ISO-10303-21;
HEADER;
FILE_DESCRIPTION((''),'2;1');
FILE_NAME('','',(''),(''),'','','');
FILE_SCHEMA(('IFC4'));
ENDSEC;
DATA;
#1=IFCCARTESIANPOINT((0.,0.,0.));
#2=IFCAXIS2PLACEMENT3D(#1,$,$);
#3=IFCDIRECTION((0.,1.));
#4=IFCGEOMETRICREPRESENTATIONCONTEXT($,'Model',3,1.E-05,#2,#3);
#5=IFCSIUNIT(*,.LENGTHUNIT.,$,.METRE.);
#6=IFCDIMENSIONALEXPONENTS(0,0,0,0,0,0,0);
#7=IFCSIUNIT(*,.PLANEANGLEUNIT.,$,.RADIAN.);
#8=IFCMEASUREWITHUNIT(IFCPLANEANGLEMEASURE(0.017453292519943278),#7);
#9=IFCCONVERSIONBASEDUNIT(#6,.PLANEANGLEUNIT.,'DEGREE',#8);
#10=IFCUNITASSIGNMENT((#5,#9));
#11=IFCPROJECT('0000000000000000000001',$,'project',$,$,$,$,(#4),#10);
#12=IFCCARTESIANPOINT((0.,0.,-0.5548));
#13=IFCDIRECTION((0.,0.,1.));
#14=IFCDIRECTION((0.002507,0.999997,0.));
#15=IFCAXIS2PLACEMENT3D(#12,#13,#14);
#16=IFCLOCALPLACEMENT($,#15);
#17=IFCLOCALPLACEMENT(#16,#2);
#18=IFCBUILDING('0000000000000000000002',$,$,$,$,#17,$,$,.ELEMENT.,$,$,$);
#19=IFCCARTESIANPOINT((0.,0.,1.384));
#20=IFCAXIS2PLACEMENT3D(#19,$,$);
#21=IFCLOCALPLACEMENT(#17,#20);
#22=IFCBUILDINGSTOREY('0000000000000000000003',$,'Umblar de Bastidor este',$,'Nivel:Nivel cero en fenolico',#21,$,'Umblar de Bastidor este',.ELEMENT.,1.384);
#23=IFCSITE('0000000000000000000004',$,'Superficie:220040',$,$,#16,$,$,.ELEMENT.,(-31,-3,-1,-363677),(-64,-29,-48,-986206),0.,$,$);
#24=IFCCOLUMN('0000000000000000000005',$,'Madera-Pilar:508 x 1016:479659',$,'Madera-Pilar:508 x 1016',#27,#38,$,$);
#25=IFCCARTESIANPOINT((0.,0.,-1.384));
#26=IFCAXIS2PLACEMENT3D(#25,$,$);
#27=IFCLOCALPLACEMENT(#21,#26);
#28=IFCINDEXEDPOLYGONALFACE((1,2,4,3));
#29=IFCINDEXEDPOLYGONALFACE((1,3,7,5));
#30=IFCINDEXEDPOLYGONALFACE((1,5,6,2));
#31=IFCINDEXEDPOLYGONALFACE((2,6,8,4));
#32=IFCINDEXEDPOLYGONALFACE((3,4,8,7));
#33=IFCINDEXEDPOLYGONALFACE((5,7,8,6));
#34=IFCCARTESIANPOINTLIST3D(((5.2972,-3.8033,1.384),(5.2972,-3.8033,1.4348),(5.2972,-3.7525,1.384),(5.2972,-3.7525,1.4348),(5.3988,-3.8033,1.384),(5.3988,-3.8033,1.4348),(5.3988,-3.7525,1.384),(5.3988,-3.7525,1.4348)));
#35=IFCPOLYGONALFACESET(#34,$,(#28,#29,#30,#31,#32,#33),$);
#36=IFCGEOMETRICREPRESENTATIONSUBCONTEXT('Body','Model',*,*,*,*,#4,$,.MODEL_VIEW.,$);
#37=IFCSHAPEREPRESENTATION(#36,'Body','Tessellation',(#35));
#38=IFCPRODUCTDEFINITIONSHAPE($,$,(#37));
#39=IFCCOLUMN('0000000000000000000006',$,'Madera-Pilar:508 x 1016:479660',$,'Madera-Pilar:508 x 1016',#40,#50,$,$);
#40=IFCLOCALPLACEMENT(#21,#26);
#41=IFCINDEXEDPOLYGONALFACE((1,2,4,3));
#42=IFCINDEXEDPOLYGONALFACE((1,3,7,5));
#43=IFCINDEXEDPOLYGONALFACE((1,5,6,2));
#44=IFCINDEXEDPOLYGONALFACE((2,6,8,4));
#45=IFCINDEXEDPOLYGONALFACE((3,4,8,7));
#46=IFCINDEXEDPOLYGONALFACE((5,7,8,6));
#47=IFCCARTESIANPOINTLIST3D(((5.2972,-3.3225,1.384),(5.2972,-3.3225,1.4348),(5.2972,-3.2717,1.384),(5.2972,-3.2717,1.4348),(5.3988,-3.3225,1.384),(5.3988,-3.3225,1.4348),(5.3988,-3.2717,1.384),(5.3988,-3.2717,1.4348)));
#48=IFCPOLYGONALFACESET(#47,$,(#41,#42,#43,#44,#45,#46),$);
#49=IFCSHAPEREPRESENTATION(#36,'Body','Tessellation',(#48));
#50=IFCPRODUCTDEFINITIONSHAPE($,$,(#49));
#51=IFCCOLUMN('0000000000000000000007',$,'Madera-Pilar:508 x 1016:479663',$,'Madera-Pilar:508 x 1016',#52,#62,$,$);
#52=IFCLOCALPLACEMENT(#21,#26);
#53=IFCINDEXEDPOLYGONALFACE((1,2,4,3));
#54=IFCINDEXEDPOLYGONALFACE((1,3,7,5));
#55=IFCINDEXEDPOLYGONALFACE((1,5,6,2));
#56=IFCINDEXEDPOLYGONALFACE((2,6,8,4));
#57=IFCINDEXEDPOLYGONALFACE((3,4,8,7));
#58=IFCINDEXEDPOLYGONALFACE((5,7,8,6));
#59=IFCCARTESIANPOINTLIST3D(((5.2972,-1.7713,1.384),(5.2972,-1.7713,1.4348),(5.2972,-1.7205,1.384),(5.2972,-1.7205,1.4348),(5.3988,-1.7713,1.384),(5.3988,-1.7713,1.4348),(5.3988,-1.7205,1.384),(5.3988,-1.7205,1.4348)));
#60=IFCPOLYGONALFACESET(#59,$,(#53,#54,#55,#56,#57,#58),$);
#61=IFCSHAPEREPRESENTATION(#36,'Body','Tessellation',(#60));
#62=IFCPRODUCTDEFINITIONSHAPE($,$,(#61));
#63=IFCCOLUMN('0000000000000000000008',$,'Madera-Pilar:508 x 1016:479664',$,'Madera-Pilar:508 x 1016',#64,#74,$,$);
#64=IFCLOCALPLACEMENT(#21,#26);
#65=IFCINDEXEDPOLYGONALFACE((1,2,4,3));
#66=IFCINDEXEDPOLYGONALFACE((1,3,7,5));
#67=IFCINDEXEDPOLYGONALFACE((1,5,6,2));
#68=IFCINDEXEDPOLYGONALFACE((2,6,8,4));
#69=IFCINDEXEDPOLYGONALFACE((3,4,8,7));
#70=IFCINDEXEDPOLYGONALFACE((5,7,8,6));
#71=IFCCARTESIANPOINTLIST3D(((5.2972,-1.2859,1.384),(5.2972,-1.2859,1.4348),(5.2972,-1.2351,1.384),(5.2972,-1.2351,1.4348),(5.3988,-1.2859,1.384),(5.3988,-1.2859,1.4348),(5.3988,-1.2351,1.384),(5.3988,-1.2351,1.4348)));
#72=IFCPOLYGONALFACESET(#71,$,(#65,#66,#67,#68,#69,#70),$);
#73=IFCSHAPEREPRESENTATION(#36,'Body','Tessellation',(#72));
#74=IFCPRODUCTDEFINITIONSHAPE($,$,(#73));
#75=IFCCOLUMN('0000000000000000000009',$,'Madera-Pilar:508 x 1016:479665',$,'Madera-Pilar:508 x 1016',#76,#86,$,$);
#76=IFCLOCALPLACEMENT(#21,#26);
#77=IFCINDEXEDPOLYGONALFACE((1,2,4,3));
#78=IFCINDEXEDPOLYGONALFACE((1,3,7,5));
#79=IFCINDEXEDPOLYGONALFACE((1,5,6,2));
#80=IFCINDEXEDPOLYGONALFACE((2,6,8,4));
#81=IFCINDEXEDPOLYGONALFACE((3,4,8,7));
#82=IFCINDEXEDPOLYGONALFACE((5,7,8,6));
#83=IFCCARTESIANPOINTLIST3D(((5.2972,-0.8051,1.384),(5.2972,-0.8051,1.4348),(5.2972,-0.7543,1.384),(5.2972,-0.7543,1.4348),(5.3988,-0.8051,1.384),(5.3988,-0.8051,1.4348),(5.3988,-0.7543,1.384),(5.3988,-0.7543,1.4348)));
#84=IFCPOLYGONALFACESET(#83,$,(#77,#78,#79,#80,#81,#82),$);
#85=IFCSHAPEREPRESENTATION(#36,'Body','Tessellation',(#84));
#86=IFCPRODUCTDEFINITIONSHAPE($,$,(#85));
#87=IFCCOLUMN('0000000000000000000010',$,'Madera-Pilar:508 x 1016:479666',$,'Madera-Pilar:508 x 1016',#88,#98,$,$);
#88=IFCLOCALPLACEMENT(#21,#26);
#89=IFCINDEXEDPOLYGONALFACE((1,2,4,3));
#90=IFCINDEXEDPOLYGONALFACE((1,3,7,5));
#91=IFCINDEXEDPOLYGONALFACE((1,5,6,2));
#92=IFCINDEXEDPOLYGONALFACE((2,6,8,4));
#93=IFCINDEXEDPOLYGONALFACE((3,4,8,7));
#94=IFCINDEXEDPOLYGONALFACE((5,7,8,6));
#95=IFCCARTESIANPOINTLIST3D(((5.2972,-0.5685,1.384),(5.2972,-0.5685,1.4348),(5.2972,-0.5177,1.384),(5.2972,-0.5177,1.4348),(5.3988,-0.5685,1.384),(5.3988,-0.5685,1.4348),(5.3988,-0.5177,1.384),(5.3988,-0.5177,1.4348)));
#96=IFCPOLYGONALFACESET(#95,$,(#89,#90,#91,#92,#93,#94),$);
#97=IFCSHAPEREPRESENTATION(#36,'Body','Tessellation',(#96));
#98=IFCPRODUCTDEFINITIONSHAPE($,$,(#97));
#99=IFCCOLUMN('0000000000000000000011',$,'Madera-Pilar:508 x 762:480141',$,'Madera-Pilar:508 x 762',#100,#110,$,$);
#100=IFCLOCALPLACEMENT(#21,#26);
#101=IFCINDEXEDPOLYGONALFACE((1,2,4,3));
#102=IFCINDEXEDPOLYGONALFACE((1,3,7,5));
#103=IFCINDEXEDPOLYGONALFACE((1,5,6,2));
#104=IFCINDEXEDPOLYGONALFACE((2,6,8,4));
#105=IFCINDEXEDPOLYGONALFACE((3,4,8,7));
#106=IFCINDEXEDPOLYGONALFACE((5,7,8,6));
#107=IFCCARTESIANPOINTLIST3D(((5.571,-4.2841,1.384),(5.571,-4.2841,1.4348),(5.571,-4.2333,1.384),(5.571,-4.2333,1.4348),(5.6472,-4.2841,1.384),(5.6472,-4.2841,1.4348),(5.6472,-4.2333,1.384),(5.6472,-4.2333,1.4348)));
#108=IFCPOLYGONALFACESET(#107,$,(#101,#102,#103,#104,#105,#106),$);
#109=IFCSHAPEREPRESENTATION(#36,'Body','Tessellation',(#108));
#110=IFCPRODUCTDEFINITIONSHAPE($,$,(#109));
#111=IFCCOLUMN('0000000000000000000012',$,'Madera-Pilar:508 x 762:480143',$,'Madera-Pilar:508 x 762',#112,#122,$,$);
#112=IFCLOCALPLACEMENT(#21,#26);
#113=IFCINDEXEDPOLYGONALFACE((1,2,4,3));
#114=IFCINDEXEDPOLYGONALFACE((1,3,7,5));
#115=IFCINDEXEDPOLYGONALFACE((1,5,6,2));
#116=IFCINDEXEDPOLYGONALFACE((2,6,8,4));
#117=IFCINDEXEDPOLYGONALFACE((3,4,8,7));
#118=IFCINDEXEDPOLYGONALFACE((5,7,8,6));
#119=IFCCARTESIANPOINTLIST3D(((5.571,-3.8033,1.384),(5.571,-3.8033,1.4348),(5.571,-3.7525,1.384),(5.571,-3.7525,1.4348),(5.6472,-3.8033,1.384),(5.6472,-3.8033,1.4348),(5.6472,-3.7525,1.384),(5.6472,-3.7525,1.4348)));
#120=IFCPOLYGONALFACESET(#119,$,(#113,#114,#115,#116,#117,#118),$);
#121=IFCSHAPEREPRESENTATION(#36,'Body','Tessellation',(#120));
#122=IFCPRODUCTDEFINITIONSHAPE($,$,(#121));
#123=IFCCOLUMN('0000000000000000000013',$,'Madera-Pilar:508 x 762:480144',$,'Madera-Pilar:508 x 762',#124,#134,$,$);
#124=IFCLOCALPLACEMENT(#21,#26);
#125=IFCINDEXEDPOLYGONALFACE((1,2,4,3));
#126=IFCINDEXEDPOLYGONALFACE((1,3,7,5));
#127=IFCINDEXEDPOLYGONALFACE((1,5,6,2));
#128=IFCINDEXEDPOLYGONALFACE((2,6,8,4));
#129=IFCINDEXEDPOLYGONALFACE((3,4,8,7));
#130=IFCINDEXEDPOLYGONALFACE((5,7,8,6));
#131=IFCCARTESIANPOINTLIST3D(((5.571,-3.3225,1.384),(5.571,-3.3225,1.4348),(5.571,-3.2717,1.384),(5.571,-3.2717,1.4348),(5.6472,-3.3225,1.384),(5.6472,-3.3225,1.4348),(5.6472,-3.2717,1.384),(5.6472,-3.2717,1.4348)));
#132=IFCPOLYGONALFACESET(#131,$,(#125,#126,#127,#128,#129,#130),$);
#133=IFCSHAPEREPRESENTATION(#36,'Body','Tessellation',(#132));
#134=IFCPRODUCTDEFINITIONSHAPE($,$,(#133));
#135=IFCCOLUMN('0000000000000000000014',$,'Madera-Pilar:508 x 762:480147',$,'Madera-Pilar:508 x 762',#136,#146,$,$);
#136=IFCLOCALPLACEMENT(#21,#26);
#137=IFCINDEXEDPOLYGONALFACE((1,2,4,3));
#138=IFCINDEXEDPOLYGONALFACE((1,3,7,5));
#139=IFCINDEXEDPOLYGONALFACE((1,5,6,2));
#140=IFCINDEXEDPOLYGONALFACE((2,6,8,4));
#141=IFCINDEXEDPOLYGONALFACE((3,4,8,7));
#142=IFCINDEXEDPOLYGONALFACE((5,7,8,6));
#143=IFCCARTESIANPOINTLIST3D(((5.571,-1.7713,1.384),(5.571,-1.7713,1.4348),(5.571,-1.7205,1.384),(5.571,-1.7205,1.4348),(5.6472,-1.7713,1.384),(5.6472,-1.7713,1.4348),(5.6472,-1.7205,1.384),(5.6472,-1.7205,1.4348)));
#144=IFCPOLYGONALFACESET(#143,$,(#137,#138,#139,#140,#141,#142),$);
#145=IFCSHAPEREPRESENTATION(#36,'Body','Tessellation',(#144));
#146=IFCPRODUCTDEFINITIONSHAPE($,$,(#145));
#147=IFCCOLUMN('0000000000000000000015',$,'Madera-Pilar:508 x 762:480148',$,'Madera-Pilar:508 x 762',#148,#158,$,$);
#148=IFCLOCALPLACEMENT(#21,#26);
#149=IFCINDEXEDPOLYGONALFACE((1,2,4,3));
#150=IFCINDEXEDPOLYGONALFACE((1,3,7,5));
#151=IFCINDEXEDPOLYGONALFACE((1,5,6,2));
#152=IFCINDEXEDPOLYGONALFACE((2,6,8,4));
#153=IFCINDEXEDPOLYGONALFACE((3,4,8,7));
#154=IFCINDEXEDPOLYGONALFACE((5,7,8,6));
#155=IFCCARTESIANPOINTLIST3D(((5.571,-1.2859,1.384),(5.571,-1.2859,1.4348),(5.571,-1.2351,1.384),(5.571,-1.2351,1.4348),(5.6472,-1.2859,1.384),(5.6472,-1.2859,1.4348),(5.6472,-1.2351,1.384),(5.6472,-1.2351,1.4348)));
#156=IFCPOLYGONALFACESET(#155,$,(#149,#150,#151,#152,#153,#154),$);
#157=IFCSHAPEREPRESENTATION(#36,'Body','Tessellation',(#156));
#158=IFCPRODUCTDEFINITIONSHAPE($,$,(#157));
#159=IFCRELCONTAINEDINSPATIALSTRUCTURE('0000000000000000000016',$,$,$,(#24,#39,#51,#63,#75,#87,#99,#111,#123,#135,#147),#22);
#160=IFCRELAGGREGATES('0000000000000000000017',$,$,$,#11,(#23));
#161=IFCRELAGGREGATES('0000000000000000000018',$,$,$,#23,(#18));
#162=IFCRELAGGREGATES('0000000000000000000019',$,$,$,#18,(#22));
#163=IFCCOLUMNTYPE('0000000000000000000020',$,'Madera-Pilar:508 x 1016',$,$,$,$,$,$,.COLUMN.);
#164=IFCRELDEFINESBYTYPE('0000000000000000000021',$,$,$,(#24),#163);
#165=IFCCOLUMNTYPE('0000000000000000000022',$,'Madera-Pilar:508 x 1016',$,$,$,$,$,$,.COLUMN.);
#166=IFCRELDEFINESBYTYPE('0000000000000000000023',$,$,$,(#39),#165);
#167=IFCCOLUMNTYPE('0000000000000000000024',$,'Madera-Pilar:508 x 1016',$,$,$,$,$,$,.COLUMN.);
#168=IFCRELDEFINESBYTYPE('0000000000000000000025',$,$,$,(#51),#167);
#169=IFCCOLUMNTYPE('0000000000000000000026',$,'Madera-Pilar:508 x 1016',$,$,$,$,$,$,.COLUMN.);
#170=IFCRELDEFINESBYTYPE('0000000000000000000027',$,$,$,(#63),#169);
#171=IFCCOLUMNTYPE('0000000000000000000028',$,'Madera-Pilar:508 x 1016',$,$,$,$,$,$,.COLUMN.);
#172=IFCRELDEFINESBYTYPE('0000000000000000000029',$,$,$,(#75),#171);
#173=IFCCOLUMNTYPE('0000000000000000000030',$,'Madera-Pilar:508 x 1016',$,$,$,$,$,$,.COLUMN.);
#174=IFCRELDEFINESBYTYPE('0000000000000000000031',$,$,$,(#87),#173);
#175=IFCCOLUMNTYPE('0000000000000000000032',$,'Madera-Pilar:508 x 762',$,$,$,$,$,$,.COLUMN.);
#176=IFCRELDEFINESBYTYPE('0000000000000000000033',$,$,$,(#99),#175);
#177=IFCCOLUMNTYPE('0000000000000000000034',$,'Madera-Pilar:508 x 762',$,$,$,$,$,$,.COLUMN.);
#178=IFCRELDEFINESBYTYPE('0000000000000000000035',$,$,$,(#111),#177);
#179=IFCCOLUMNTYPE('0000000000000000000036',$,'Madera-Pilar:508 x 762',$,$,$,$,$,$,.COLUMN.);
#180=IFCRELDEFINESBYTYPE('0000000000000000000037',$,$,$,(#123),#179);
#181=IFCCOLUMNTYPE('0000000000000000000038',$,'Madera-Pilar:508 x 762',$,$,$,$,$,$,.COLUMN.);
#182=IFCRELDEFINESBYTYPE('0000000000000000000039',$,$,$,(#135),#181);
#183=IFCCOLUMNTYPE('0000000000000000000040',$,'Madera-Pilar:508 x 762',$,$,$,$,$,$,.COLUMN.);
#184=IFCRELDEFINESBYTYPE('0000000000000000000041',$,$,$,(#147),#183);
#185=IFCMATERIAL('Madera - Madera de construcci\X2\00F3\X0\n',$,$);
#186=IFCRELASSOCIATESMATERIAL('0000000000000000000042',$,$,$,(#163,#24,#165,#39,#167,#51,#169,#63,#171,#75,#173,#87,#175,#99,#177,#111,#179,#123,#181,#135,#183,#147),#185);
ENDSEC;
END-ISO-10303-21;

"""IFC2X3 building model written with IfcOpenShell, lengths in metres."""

from ifc_helpers import new_model, entity, si_unit, converted_unit, direction, frame, frame_2d, origin, origin_2d_with_axis, place, context, subcontext, project, spatial, rectangle, extrude, source, transform, mapped, material, type_object, type_shapes, element, save


model = new_model("IFC2X3")

# Units and contexts
model_context = context("Model", 3, precision=1e-05, world=origin(), true_north=direction((0.0, 1.0)))
body_context = subcontext(model_context, "Body", "Model", "MODEL_VIEW")
ifc_project = project(units=[si_unit("LENGTHUNIT", "METRE"), converted_unit("PLANEANGLEUNIT", "DEGREE", entity("IfcPlaneAngleMeasure", 0.017453292519943278), si_unit("PLANEANGLEUNIT", "RADIAN"), dimensions=[0, 0, 0, 0, 0, 0, 0])], contexts=[model_context])

# Site, building, storey
site_placement = place(None, frame((0.0, 0.0, -0.5548), z_axis=(0.0, 0.0, 1.0), x_axis=(0.002507, 0.999997, 0.0)))
site = spatial("IfcSite", under=ifc_project, at=site_placement, Name="Superficie:220040", CompositionType="ELEMENT", RefLatitude=(-31, -3, -1, -363677), RefLongitude=(-64, -29, -48, -986206), RefElevation=0.0)
building_placement = place(site_placement, origin())
building = spatial("IfcBuilding", under=site, at=building_placement, CompositionType="ELEMENT")
storey_placement = place(building_placement, frame((0.0, 0.0, 1.384)))
storey = spatial("IfcBuildingStorey", under=building, at=storey_placement, Name="Umblar de Bastidor este", ObjectType="Nivel:Nivel cero en fenolico", LongName="Umblar de Bastidor este", CompositionType="ELEMENT", Elevation=1.384)

# Columns
ifc_material = material(Name="Madera - Madera de construcción")
column_type_1 = type_object("IfcColumnType", Name="Madera-Pilar:508 x 1016", PredefinedType="COLUMN", material=ifc_material)
shared_shape_1 = source(origin(), body_context, "Body", "SweptSolid", [
    extrude(rectangle(XDim=0.1016, YDim=0.0508, at=origin_2d_with_axis()), frame((5.348, -3.7779, 1.384), z_axis=(0.0, 0.0, 1.0), x_axis=(-1.0, 0.0, 0.0)), (0.0, 0.0, 1.0), 0.0508),
])
type_shapes(column_type_1, [shared_shape_1])
column_1_placement = place(storey_placement, frame((0.0, 0.0, -1.384)))
element("IfcColumn", 1, at=column_1_placement, inside=storey, type_object=column_type_1, material=ifc_material, Name="Madera-Pilar:508 x 1016:479659", ObjectType="Madera-Pilar:508 x 1016", context=body_context, shape_type="MappedRepresentation", body=[
    mapped(shared_shape_1, transform((0.0, 0.0, 0.0), scale=1.0)),
])
column_type_2 = type_object("IfcColumnType", Name="Madera-Pilar:508 x 1016", PredefinedType="COLUMN", material=ifc_material)
shared_shape_2 = source(origin(), body_context, "Body", "SweptSolid", [
    extrude(rectangle(XDim=0.1016, YDim=0.0508, at=origin_2d_with_axis()), frame((5.348, -3.2971, 1.384), z_axis=(0.0, 0.0, 1.0), x_axis=(-1.0, 0.0, 0.0)), (0.0, 0.0, 1.0), 0.0508),
])
type_shapes(column_type_2, [shared_shape_2])
column_2_placement = place(storey_placement, frame((0.0, 0.0, -1.384)))
element("IfcColumn", 2, at=column_2_placement, inside=storey, type_object=column_type_2, material=ifc_material, Name="Madera-Pilar:508 x 1016:479660", ObjectType="Madera-Pilar:508 x 1016", context=body_context, shape_type="MappedRepresentation", body=[
    mapped(shared_shape_2, transform((0.0, 0.0, 0.0), scale=1.0)),
])
column_type_3 = type_object("IfcColumnType", Name="Madera-Pilar:508 x 1016", PredefinedType="COLUMN", material=ifc_material)
shared_shape_3 = source(origin(), body_context, "Body", "SweptSolid", [
    extrude(rectangle(XDim=0.1016, YDim=0.0508, at=origin_2d_with_axis()), frame((5.348, -1.7459, 1.384), z_axis=(0.0, 0.0, 1.0), x_axis=(-1.0, 0.0, 0.0)), (0.0, 0.0, 1.0), 0.0508),
])
type_shapes(column_type_3, [shared_shape_3])
column_3_placement = place(storey_placement, frame((0.0, 0.0, -1.384)))
element("IfcColumn", 3, at=column_3_placement, inside=storey, type_object=column_type_3, material=ifc_material, Name="Madera-Pilar:508 x 1016:479663", ObjectType="Madera-Pilar:508 x 1016", context=body_context, shape_type="MappedRepresentation", body=[
    mapped(shared_shape_3, transform((0.0, 0.0, 0.0), scale=1.0)),
])
column_type_4 = type_object("IfcColumnType", Name="Madera-Pilar:508 x 1016", PredefinedType="COLUMN", material=ifc_material)
shared_shape_4 = source(origin(), body_context, "Body", "SweptSolid", [
    extrude(rectangle(XDim=0.1016, YDim=0.0508, at=origin_2d_with_axis()), frame((5.348, -1.2605, 1.384), z_axis=(0.0, 0.0, 1.0), x_axis=(-1.0, 0.0, 0.0)), (0.0, 0.0, 1.0), 0.0508),
])
type_shapes(column_type_4, [shared_shape_4])
column_4_placement = place(storey_placement, frame((0.0, 0.0, -1.384)))
element("IfcColumn", 4, at=column_4_placement, inside=storey, type_object=column_type_4, material=ifc_material, Name="Madera-Pilar:508 x 1016:479664", ObjectType="Madera-Pilar:508 x 1016", context=body_context, shape_type="MappedRepresentation", body=[
    mapped(shared_shape_4, transform((0.0, 0.0, 0.0), scale=1.0)),
])
column_type_5 = type_object("IfcColumnType", Name="Madera-Pilar:508 x 1016", PredefinedType="COLUMN", material=ifc_material)
shared_shape_5 = source(origin(), body_context, "Body", "SweptSolid", [
    extrude(rectangle(XDim=0.1016, YDim=0.0508, at=frame_2d((0.0, 0.0), x_axis=(1.0, 0.0))), frame((5.348, -0.7797, 1.384), z_axis=(0.0, 0.0, 1.0), x_axis=(-1.0, 0.0, 0.0)), (0.0, 0.0, 1.0), 0.0508),
])
type_shapes(column_type_5, [shared_shape_5])
column_5_placement = place(storey_placement, frame((0.0, 0.0, -1.384)))
element("IfcColumn", 5, at=column_5_placement, inside=storey, type_object=column_type_5, material=ifc_material, Name="Madera-Pilar:508 x 1016:479665", ObjectType="Madera-Pilar:508 x 1016", context=body_context, shape_type="MappedRepresentation", body=[
    mapped(shared_shape_5, transform((0.0, 0.0, 0.0), scale=1.0)),
])
column_type_6 = type_object("IfcColumnType", Name="Madera-Pilar:508 x 1016", PredefinedType="COLUMN", material=ifc_material)
shared_shape_6 = source(origin(), body_context, "Body", "SweptSolid", [
    extrude(rectangle(XDim=0.1016, YDim=0.0508, at=origin_2d_with_axis()), frame((5.348, -0.5431, 1.384), z_axis=(0.0, 0.0, 1.0), x_axis=(-1.0, 0.0, 0.0)), (0.0, 0.0, 1.0), 0.0508),
])
type_shapes(column_type_6, [shared_shape_6])
column_6_placement = place(storey_placement, frame((0.0, 0.0, -1.384)))
element("IfcColumn", 6, at=column_6_placement, inside=storey, type_object=column_type_6, material=ifc_material, Name="Madera-Pilar:508 x 1016:479666", ObjectType="Madera-Pilar:508 x 1016", context=body_context, shape_type="MappedRepresentation", body=[
    mapped(shared_shape_6, transform((0.0, 0.0, 0.0), scale=1.0)),
])
column_type_7 = type_object("IfcColumnType", Name="Madera-Pilar:508 x 762", PredefinedType="COLUMN", material=ifc_material)
shared_shape_7 = source(origin(), body_context, "Body", "SweptSolid", [
    extrude(rectangle(XDim=0.0762, YDim=0.0508, at=origin_2d_with_axis()), frame((5.6091, -4.2587, 1.384), z_axis=(0.0, 0.0, 1.0), x_axis=(-1.0, 0.0, 0.0)), (0.0, 0.0, 1.0), 0.0508),
])
type_shapes(column_type_7, [shared_shape_7])
column_7_placement = place(storey_placement, frame((0.0, 0.0, -1.384)))
element("IfcColumn", 7, at=column_7_placement, inside=storey, type_object=column_type_7, material=ifc_material, Name="Madera-Pilar:508 x 762:480141", ObjectType="Madera-Pilar:508 x 762", context=body_context, shape_type="MappedRepresentation", body=[
    mapped(shared_shape_7, transform((0.0, 0.0, 0.0), scale=1.0)),
])
column_type_8 = type_object("IfcColumnType", Name="Madera-Pilar:508 x 762", PredefinedType="COLUMN", material=ifc_material)
shared_shape_8 = source(origin(), body_context, "Body", "SweptSolid", [
    extrude(rectangle(XDim=0.0762, YDim=0.0508, at=origin_2d_with_axis()), frame((5.6091, -3.7779, 1.384), z_axis=(0.0, 0.0, 1.0), x_axis=(-1.0, 0.0, 0.0)), (0.0, 0.0, 1.0), 0.0508),
])
type_shapes(column_type_8, [shared_shape_8])
column_8_placement = place(storey_placement, frame((0.0, 0.0, -1.384)))
element("IfcColumn", 8, at=column_8_placement, inside=storey, type_object=column_type_8, material=ifc_material, Name="Madera-Pilar:508 x 762:480143", ObjectType="Madera-Pilar:508 x 762", context=body_context, shape_type="MappedRepresentation", body=[
    mapped(shared_shape_8, transform((0.0, 0.0, 0.0), scale=1.0)),
])
column_type_9 = type_object("IfcColumnType", Name="Madera-Pilar:508 x 762", PredefinedType="COLUMN", material=ifc_material)
shared_shape_9 = source(origin(), body_context, "Body", "SweptSolid", [
    extrude(rectangle(XDim=0.0762, YDim=0.0508, at=origin_2d_with_axis()), frame((5.6091, -3.2971, 1.384), z_axis=(0.0, 0.0, 1.0), x_axis=(-1.0, 0.0, 0.0)), (0.0, 0.0, 1.0), 0.0508),
])
type_shapes(column_type_9, [shared_shape_9])
column_9_placement = place(storey_placement, frame((0.0, 0.0, -1.384)))
element("IfcColumn", 9, at=column_9_placement, inside=storey, type_object=column_type_9, material=ifc_material, Name="Madera-Pilar:508 x 762:480144", ObjectType="Madera-Pilar:508 x 762", context=body_context, shape_type="MappedRepresentation", body=[
    mapped(shared_shape_9, transform((0.0, 0.0, 0.0), scale=1.0)),
])
column_type_10 = type_object("IfcColumnType", Name="Madera-Pilar:508 x 762", PredefinedType="COLUMN", material=ifc_material)
shared_shape_10 = source(origin(), body_context, "Body", "SweptSolid", [
    extrude(rectangle(XDim=0.0762, YDim=0.0508, at=origin_2d_with_axis()), frame((5.6091, -1.7459, 1.384), z_axis=(0.0, 0.0, 1.0), x_axis=(-1.0, 0.0, 0.0)), (0.0, 0.0, 1.0), 0.0508),
])
type_shapes(column_type_10, [shared_shape_10])
column_10_placement = place(storey_placement, frame((0.0, 0.0, -1.384)))
element("IfcColumn", 10, at=column_10_placement, inside=storey, type_object=column_type_10, material=ifc_material, Name="Madera-Pilar:508 x 762:480147", ObjectType="Madera-Pilar:508 x 762", context=body_context, shape_type="MappedRepresentation", body=[
    mapped(shared_shape_10, transform((0.0, 0.0, 0.0), scale=1.0)),
])
column_type_11 = type_object("IfcColumnType", Name="Madera-Pilar:508 x 762", PredefinedType="COLUMN", material=ifc_material)
shared_shape_11 = source(origin(), body_context, "Body", "SweptSolid", [
    extrude(rectangle(XDim=0.0762, YDim=0.0508, at=origin_2d_with_axis()), frame((5.6091, -1.2605, 1.384), z_axis=(0.0, 0.0, 1.0), x_axis=(-1.0, 0.0, 0.0)), (0.0, 0.0, 1.0), 0.0508),
])
type_shapes(column_type_11, [shared_shape_11])
column_11_placement = place(storey_placement, frame((0.0, 0.0, -1.384)))
element("IfcColumn", 11, at=column_11_placement, inside=storey, type_object=column_type_11, material=ifc_material, Name="Madera-Pilar:508 x 762:480148", ObjectType="Madera-Pilar:508 x 762", context=body_context, shape_type="MappedRepresentation", body=[
    mapped(shared_shape_11, transform((0.0, 0.0, 0.0), scale=1.0)),
])

save(model, "model.ifc")
